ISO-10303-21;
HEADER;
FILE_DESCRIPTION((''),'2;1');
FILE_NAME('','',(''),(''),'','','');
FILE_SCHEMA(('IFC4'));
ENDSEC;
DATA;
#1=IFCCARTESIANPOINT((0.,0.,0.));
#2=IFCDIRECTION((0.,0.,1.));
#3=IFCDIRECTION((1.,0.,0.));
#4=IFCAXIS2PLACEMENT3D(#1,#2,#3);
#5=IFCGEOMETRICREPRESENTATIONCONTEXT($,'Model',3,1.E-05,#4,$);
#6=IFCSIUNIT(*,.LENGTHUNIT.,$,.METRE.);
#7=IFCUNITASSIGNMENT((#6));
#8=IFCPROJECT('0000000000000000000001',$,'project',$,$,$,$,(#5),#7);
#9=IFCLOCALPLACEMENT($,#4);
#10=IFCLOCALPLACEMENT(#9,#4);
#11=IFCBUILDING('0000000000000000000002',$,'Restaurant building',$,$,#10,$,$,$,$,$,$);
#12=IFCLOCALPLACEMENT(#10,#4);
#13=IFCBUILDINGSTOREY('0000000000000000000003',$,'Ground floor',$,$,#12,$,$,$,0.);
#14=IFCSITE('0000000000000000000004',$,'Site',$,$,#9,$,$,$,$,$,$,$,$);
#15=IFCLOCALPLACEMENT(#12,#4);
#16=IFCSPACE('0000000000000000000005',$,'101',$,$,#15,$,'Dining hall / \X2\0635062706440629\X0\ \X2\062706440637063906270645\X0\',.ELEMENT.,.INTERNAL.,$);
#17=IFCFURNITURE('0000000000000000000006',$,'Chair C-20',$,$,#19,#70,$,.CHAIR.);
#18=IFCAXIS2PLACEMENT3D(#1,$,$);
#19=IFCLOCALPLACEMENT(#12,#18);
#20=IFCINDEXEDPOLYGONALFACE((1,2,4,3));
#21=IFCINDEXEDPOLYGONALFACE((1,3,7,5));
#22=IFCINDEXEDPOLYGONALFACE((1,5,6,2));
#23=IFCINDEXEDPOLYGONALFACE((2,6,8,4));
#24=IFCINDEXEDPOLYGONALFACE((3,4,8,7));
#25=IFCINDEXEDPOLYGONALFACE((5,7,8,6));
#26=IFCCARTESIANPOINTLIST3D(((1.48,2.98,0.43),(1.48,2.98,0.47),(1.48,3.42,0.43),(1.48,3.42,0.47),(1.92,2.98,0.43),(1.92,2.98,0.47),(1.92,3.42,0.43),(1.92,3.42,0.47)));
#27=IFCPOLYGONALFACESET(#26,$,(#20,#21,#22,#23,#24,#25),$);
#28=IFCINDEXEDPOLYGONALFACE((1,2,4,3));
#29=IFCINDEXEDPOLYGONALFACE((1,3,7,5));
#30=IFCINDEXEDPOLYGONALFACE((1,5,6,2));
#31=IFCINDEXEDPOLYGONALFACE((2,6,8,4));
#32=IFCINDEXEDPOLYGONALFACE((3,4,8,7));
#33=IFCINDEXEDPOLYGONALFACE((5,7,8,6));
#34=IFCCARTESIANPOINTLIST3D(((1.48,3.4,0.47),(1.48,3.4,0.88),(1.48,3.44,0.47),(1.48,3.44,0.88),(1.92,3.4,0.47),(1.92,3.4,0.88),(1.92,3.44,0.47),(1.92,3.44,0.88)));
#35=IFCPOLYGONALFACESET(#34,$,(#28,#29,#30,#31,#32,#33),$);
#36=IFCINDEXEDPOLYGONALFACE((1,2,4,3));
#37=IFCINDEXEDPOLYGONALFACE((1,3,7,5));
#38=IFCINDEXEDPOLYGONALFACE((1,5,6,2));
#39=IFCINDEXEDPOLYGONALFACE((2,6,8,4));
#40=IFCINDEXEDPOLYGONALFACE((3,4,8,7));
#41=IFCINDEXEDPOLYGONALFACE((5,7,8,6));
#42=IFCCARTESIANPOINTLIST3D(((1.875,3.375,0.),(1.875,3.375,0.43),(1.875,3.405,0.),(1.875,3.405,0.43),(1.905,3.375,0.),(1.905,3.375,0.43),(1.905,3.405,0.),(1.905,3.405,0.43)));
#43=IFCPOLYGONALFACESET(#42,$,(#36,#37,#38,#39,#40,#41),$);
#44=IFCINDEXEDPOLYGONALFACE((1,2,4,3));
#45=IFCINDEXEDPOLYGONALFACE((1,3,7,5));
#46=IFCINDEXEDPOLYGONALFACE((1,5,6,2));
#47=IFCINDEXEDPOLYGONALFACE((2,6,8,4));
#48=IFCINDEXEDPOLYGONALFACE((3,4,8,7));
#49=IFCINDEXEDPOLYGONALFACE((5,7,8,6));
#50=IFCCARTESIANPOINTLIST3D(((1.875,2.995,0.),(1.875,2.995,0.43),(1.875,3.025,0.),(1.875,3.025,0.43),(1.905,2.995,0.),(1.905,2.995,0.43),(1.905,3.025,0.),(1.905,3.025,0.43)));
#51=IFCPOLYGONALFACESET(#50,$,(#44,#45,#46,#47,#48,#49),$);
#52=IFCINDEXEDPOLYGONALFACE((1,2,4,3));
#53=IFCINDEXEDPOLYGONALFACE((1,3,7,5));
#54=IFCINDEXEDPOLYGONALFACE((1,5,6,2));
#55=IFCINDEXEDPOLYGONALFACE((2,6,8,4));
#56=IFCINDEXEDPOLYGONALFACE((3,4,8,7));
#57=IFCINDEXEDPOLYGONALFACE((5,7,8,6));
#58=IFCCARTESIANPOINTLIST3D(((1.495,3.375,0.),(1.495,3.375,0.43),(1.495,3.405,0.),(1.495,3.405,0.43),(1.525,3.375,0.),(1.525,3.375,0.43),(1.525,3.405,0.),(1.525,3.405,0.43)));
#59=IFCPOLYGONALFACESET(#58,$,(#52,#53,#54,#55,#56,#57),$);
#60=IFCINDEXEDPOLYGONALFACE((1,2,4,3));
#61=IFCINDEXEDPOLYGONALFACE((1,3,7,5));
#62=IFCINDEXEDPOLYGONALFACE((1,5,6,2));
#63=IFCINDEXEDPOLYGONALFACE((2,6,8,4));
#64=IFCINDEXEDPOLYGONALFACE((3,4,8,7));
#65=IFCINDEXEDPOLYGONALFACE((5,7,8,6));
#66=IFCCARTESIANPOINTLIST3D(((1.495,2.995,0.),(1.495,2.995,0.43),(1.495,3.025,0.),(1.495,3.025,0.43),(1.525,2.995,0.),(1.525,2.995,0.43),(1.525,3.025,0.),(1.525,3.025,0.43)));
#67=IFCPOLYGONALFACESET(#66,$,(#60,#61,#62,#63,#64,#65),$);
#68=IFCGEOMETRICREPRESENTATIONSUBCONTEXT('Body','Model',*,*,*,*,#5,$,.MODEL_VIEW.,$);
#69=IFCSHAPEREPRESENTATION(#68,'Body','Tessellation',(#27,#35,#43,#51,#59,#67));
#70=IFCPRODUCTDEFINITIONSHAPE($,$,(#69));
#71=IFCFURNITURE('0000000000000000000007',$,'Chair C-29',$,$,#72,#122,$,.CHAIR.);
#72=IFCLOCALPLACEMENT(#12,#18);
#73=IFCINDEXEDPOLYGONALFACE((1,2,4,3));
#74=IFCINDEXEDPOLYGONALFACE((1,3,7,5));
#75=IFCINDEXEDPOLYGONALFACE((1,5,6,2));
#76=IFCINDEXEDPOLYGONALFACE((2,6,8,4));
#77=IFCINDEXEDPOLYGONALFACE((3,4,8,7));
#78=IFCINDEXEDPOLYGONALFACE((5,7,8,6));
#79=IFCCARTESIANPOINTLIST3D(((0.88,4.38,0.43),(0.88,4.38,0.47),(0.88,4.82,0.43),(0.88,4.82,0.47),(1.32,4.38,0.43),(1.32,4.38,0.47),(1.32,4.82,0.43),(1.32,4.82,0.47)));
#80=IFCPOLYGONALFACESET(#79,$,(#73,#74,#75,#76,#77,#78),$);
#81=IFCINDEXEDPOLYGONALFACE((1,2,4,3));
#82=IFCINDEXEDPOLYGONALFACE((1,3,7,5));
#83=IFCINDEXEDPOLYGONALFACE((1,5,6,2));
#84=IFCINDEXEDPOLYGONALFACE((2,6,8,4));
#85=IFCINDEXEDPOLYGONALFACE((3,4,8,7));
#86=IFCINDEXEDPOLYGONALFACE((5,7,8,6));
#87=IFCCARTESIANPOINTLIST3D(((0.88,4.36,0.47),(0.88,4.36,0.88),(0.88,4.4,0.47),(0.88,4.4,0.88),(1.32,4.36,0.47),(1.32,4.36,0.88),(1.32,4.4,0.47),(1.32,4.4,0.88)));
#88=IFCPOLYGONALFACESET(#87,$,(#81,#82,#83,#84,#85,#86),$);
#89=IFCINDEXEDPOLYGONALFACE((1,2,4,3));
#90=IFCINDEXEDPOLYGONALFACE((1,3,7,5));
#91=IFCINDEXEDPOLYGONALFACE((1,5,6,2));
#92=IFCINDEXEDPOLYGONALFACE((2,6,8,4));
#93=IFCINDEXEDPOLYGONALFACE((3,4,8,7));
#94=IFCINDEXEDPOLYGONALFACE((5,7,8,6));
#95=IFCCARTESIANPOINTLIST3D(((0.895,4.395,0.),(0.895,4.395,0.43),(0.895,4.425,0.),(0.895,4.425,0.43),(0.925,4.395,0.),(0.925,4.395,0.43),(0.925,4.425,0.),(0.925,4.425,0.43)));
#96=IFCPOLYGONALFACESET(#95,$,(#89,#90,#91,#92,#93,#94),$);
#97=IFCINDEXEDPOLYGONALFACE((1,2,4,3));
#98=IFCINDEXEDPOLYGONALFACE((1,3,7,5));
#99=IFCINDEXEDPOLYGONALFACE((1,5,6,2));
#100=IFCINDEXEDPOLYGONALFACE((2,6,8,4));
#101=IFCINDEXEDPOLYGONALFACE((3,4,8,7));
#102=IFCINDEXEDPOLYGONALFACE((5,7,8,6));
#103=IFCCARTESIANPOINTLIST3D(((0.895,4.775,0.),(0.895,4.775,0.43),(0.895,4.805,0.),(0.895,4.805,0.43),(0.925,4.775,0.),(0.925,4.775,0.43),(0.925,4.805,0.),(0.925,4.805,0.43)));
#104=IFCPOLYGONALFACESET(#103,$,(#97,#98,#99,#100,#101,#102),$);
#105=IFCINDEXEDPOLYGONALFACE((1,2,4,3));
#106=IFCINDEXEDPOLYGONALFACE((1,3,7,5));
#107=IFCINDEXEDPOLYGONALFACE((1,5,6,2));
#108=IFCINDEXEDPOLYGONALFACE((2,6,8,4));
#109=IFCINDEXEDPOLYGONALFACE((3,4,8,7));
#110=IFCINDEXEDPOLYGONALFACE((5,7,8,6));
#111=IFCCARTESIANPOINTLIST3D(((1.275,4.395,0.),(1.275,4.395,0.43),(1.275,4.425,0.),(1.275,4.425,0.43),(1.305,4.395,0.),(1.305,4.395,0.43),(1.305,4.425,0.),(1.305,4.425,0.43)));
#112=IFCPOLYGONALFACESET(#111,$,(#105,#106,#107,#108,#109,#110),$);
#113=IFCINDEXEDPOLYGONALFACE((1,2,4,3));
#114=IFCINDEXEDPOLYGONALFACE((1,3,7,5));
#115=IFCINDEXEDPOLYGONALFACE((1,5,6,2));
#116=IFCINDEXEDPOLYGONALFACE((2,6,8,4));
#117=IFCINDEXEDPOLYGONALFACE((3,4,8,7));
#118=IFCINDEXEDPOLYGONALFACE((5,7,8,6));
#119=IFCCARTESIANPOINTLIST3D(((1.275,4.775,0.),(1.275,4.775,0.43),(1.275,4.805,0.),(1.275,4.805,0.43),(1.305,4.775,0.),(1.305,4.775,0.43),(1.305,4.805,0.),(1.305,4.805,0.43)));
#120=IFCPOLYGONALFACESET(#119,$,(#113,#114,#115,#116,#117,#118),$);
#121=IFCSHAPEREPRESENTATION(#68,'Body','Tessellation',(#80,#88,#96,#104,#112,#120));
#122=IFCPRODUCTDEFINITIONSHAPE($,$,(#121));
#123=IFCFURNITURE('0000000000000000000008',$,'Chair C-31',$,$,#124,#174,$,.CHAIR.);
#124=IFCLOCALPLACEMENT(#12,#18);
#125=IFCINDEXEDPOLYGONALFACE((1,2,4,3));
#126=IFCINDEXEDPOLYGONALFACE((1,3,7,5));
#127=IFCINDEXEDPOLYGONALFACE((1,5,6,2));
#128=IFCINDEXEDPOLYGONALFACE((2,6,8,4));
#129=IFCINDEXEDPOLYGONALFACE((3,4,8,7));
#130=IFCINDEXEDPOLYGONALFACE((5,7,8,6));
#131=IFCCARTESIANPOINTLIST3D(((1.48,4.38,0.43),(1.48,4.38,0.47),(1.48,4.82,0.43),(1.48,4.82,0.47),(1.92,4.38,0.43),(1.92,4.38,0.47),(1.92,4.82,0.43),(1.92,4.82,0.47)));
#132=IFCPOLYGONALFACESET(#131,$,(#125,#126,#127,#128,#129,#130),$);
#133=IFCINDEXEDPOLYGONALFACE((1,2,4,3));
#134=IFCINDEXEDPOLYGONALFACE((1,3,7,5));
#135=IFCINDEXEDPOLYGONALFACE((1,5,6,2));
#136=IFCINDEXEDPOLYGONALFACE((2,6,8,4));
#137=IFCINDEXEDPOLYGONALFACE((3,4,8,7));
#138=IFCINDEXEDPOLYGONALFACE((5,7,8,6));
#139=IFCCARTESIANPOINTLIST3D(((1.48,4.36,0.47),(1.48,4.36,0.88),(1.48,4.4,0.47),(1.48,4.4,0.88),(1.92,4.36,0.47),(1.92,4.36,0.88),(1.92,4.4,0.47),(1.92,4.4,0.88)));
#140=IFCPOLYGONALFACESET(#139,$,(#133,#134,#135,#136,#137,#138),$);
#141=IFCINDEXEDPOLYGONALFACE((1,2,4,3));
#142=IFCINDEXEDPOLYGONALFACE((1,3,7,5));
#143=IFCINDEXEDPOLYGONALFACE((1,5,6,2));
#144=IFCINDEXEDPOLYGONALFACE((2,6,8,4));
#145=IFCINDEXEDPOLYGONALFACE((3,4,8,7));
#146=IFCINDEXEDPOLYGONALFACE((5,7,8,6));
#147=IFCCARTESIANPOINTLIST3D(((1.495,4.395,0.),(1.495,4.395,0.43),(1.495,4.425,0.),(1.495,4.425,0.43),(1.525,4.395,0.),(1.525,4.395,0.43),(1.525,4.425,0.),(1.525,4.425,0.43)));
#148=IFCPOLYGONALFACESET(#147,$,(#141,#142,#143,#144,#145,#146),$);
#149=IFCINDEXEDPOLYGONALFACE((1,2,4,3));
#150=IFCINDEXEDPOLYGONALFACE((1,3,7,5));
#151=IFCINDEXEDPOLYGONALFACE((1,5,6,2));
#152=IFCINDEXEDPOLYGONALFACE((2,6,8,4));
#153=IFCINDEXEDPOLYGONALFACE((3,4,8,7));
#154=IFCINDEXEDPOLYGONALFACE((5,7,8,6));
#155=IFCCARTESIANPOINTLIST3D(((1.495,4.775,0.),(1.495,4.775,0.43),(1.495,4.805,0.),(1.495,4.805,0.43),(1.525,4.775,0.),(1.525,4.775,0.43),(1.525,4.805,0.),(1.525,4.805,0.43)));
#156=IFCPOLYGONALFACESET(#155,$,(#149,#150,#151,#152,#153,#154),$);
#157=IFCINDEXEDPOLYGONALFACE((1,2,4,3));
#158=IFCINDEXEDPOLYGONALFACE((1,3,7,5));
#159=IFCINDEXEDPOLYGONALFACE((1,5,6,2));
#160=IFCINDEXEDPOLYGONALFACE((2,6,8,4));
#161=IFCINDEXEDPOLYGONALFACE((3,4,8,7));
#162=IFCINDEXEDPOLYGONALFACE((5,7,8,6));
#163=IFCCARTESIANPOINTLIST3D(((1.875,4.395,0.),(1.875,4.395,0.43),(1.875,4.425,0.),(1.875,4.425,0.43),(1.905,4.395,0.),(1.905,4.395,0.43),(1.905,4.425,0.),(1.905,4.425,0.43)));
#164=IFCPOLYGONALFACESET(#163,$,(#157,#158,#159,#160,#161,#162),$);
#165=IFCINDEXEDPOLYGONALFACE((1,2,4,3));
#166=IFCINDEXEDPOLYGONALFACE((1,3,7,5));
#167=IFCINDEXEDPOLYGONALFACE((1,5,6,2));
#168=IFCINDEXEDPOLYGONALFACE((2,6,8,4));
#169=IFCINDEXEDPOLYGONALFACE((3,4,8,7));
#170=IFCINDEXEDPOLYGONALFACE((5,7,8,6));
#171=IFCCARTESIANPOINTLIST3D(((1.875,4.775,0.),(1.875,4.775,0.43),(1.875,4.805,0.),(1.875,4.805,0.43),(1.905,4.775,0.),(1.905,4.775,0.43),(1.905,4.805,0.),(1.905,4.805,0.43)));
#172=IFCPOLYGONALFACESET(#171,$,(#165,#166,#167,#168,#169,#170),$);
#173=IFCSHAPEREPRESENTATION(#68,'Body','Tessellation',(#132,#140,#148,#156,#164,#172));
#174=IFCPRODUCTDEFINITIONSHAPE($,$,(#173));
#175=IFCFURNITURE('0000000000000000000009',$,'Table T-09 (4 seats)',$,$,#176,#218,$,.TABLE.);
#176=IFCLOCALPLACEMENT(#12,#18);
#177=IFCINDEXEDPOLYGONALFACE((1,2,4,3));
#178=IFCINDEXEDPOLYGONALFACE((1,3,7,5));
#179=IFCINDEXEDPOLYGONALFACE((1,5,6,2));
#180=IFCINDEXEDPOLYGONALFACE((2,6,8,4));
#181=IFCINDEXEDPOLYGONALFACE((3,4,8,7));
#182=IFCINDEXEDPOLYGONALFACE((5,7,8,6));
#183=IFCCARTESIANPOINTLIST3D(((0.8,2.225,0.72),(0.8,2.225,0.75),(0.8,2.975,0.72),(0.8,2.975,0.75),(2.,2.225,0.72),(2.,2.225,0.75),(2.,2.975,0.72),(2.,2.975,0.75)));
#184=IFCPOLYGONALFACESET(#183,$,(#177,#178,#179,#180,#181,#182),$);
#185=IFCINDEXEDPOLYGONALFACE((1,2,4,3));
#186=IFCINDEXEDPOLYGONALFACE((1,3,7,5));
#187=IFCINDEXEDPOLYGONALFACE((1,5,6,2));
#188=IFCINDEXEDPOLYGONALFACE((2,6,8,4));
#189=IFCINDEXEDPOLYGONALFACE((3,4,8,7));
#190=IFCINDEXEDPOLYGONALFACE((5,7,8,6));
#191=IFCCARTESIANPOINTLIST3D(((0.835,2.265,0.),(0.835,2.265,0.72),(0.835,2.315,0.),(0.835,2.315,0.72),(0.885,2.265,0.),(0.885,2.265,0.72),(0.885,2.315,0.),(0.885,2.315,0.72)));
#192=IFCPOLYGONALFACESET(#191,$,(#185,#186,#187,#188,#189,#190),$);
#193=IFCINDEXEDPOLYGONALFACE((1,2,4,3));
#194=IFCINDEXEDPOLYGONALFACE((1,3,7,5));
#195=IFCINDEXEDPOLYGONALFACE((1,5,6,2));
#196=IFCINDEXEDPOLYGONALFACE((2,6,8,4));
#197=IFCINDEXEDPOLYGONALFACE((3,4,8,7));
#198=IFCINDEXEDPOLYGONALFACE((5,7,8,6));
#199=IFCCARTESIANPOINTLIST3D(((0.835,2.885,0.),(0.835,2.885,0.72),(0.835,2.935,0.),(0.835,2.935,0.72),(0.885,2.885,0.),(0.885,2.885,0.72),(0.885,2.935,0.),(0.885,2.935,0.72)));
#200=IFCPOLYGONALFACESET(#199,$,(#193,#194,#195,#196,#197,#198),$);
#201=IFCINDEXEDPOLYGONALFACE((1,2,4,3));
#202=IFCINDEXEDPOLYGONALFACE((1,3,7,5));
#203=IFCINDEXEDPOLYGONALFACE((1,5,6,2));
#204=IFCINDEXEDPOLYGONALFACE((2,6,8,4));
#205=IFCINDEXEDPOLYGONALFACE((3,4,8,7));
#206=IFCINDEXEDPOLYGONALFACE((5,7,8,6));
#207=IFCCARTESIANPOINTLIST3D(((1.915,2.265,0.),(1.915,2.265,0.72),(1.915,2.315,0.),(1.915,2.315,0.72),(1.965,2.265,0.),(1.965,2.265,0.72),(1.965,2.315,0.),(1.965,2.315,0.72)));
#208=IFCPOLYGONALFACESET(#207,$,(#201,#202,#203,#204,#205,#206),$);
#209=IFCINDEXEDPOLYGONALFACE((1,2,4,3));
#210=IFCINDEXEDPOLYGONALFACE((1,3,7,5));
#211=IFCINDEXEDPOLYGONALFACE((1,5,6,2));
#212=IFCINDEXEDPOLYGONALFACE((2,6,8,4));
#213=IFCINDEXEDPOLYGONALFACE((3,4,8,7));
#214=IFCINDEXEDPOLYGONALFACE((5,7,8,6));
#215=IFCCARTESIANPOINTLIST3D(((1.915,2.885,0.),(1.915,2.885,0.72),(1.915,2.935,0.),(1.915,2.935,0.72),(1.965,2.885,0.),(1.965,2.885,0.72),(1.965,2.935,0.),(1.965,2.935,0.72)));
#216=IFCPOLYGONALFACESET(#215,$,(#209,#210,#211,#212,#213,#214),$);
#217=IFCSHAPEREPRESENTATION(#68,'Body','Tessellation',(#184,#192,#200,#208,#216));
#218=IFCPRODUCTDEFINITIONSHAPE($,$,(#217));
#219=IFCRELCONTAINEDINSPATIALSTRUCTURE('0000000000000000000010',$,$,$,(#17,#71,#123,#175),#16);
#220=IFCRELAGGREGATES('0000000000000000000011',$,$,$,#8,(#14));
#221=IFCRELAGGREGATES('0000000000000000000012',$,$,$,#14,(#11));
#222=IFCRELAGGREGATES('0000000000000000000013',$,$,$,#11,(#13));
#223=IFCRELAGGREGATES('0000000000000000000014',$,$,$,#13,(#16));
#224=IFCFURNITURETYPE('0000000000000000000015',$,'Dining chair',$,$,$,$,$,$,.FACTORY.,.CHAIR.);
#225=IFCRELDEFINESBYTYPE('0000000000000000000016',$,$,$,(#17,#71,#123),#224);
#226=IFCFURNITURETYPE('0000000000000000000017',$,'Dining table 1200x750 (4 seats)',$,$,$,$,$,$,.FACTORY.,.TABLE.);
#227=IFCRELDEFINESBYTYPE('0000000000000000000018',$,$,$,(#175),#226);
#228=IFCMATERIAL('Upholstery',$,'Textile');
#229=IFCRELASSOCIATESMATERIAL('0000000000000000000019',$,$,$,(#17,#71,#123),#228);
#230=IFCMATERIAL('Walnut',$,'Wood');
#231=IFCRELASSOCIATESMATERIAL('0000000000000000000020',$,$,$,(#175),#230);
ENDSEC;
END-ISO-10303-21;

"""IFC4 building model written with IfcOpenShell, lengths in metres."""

from ifc_helpers import new_model, si_unit, frame, origin, origin_with_axes, origin_2d, place, context, subcontext, project, spatial, rectangle, extrude, source, transform, mapped, material, type_object, type_shapes, element, save


model = new_model("IFC4")

# Units and contexts
model_context = context("Model", 3, precision=1e-05, world=origin_with_axes())
body_context = subcontext(model_context, "Body", "Model", "MODEL_VIEW")
ifc_project = project(units=[si_unit("LENGTHUNIT", "METRE")], contexts=[model_context])

# Site, building, storey
site_placement = place(None, origin_with_axes())
site = spatial("IfcSite", under=ifc_project, at=site_placement, Name="Site")
building_placement = place(site_placement, origin_with_axes())
building = spatial("IfcBuilding", under=site, at=building_placement, Name="Restaurant building")
storey_placement = place(building_placement, origin_with_axes())
storey = spatial("IfcBuildingStorey", under=building, at=storey_placement, Name="Ground floor", Elevation=0.0)

# Shared definitions
space_placement = place(storey_placement, origin_with_axes())
space = spatial("IfcSpace", under=storey, at=space_placement, Name="101", LongName="Dining hall / صالة الطعام", CompositionType="ELEMENT", PredefinedType="INTERNAL")

# Furniture
ifc_material_1 = material(Name="Upholstery", Category="Textile")
furniture_type_1 = type_object("IfcFurnitureType", Name="Dining chair", AssemblyPlace="FACTORY", PredefinedType="CHAIR")
shared_shape_1 = source(origin(), body_context, "Body", "SweptSolid", [
    extrude(rectangle(XDim=0.44, YDim=0.44, at=origin_2d()), frame((0.0, 0.0, 0.43)), (0.0, 0.0, 1.0), 0.04),
    extrude(rectangle(XDim=0.44, YDim=0.04, at=origin_2d()), frame((0.0, -0.22, 0.47)), (0.0, 0.0, 1.0), 0.41),
    extrude(rectangle(XDim=0.03, YDim=0.03, at=origin_2d()), frame((-0.19, -0.19, 0.0)), (0.0, 0.0, 1.0), 0.43),
    extrude(rectangle(XDim=0.03, YDim=0.03, at=origin_2d()), frame((-0.19, 0.19, 0.0)), (0.0, 0.0, 1.0), 0.43),
    extrude(rectangle(XDim=0.03, YDim=0.03, at=origin_2d()), frame((0.19, -0.19, 0.0)), (0.0, 0.0, 1.0), 0.43),
    extrude(rectangle(XDim=0.03, YDim=0.03, at=origin_2d()), frame((0.19, 0.19, 0.0)), (0.0, 0.0, 1.0), 0.43),
])
type_shapes(furniture_type_1, [shared_shape_1])
for number, where, z_axis, x_axis, name in (
    (1, (1.7, 3.2, 0.0), (0.0, 0.0, 1.0), (-1.0, 0.0, 0.0), "Chair C-20"),
):
    element("IfcFurniture", number, at=place(storey_placement, frame(where, z_axis=z_axis, x_axis=x_axis)), inside=space, type_object=furniture_type_1, material=ifc_material_1, Name=name, PredefinedType="CHAIR", context=body_context, shape_type="MappedRepresentation", body=[
        mapped(shared_shape_1, transform((0.0, 0.0, 0.0))),
    ])
for number, where, name in (
    (2, (1.1, 4.6, 0.0), "Chair C-29"),
    (3, (1.7, 4.6, 0.0), "Chair C-31"),
):
    element("IfcFurniture", number, at=place(storey_placement, frame(where)), inside=space, type_object=furniture_type_1, material=ifc_material_1, Name=name, PredefinedType="CHAIR", context=body_context, shape_type="MappedRepresentation", body=[
        mapped(shared_shape_1, transform((0.0, 0.0, 0.0))),
    ])
ifc_material_2 = material(Name="Walnut", Category="Wood")
furniture_type_2 = type_object("IfcFurnitureType", Name="Dining table 1200x750 (4 seats)", AssemblyPlace="FACTORY", PredefinedType="TABLE")
shared_shape_2 = source(origin(), body_context, "Body", "SweptSolid", [
    extrude(rectangle(XDim=1.2, YDim=0.75, at=origin_2d()), frame((0.0, 0.0, 0.72)), (0.0, 0.0, 1.0), 0.03),
    extrude(rectangle(XDim=0.05, YDim=0.05, at=origin_2d()), frame((-0.54, -0.31, 0.0)), (0.0, 0.0, 1.0), 0.72),
    extrude(rectangle(XDim=0.05, YDim=0.05, at=origin_2d()), frame((-0.54, 0.31, 0.0)), (0.0, 0.0, 1.0), 0.72),
    extrude(rectangle(XDim=0.05, YDim=0.05, at=origin_2d()), frame((0.54, -0.31, 0.0)), (0.0, 0.0, 1.0), 0.72),
    extrude(rectangle(XDim=0.05, YDim=0.05, at=origin_2d()), frame((0.54, 0.31, 0.0)), (0.0, 0.0, 1.0), 0.72),
])
type_shapes(furniture_type_2, [shared_shape_2])
furniture_placement = place(storey_placement, frame((1.4, 2.6, 0.0)))
element("IfcFurniture", 4, at=furniture_placement, inside=space, type_object=furniture_type_2, material=ifc_material_2, Name="Table T-09 (4 seats)", PredefinedType="TABLE", context=body_context, shape_type="MappedRepresentation", body=[
    mapped(shared_shape_2, transform((0.0, 0.0, 0.0))),
])

save(model, "model.ifc")
